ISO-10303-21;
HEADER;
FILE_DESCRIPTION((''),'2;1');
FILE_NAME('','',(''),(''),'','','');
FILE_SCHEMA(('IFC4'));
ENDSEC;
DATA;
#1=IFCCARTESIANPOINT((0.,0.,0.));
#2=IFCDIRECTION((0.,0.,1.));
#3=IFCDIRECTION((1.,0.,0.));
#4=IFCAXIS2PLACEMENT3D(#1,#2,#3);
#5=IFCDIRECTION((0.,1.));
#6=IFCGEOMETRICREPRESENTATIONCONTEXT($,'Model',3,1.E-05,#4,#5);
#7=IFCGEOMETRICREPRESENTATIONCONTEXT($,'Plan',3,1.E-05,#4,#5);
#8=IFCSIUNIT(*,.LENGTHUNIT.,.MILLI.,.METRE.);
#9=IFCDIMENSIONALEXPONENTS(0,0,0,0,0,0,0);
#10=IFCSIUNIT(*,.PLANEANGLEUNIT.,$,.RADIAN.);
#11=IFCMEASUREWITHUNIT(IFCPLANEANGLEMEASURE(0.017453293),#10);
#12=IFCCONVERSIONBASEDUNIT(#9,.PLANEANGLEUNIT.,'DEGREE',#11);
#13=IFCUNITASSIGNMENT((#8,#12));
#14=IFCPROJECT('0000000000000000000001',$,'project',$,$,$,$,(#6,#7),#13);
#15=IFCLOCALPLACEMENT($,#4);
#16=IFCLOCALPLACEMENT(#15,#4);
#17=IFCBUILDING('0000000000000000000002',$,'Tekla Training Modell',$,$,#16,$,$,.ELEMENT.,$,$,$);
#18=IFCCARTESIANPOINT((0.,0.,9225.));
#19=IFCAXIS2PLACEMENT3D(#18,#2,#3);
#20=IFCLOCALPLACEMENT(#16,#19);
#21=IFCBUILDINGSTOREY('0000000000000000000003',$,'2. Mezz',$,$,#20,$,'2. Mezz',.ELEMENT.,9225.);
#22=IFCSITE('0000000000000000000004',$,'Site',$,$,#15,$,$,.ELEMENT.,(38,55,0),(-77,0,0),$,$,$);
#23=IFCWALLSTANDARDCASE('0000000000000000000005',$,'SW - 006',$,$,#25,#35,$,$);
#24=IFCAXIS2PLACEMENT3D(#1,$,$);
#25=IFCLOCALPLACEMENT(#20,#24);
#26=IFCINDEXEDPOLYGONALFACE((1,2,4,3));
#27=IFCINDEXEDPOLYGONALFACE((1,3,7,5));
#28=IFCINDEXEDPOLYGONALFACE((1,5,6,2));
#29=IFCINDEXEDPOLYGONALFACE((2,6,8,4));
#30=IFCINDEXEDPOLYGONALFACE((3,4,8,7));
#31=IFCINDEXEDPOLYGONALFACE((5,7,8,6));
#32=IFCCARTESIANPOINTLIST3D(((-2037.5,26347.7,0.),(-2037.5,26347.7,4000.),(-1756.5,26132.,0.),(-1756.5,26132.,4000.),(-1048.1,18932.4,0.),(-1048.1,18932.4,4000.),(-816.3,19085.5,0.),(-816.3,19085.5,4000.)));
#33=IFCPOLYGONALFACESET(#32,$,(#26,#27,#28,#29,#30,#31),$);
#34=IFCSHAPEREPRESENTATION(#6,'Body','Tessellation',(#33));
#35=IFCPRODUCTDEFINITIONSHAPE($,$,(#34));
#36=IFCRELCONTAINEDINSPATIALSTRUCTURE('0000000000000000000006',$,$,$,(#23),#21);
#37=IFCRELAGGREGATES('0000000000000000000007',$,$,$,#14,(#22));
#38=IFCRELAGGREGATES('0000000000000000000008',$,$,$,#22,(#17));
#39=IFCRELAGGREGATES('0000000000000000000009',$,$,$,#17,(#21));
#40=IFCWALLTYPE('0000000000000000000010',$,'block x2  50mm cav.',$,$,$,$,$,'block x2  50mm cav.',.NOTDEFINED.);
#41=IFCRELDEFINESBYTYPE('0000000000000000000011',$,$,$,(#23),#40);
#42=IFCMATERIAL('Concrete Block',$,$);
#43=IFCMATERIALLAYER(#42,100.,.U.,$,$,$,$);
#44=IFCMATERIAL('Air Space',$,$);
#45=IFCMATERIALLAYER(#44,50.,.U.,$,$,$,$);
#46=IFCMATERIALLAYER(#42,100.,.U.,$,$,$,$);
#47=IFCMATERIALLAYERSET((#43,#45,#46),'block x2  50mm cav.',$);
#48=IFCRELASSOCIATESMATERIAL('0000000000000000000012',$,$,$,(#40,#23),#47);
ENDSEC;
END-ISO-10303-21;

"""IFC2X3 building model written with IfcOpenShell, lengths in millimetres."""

from ifc_helpers import new_model, entity, si_unit, converted_unit, direction, frame, origin_with_axes, place, context, project, spatial, polyline, outline, extrude, material, layer, layer_set, layer_usage, type_object, element, save


model = new_model("IFC2X3")

# Units and contexts
model_context = context("Model", 3, precision=1e-05, world=origin_with_axes(), true_north=direction((0.0, 1.0)))
plan_context = context("Plan", 3, precision=1e-05, world=origin_with_axes(), true_north=direction((0.0, 1.0)))
ifc_project = project(units=[si_unit("LENGTHUNIT", "METRE", prefix="MILLI"), converted_unit("PLANEANGLEUNIT", "DEGREE", entity("IfcPlaneAngleMeasure", 0.017453293), si_unit("PLANEANGLEUNIT", "RADIAN"), dimensions=[0, 0, 0, 0, 0, 0, 0])], contexts=[model_context, plan_context])

# Site, building, storey
site_placement = place(None, origin_with_axes())
site = spatial("IfcSite", under=ifc_project, at=site_placement, Name="Site", CompositionType="ELEMENT", RefLatitude=(38, 55, 0), RefLongitude=(-77, 0, 0))
building_placement = place(site_placement, origin_with_axes())
building = spatial("IfcBuilding", under=site, at=building_placement, Name="Tekla Training Modell", CompositionType="ELEMENT")
storey_placement = place(building_placement, frame((0.0, 0.0, 9225.0), z_axis=(0.0, 0.0, 1.0), x_axis=(1.0, 0.0, 0.0)))
storey = spatial("IfcBuildingStorey", under=building, at=storey_placement, Name="2. Mezz", LongName="2. Mezz", CompositionType="ELEMENT", Elevation=9225.0)

# Wall
ifc_material_1 = material(Name="Concrete Block")
ifc_layer_1 = layer(ifc_material_1, 100.0, ventilated="UNKNOWN")
ifc_material_2 = material(Name="Air Space")
ifc_layer_2 = layer(ifc_material_2, 50.0, ventilated="UNKNOWN")
ifc_layer_3 = layer(ifc_material_1, 100.0, ventilated="UNKNOWN")
ifc_layer_set_1 = layer_set([ifc_layer_1, ifc_layer_2, ifc_layer_3], Name="block x2  50mm cav.")
wall_type = type_object("IfcWallType", Name="block x2  50mm cav.", ElementType="block x2  50mm cav.", PredefinedType="NOTDEFINED", material=ifc_layer_set_1)
ifc_layer_usage_1 = layer_usage(ifc_layer_set_1, "AXIS2", "NEGATIVE", 0.0)
wall_1_placement = place(storey_placement, frame((-1756.5, 26132.0, 0.0), z_axis=(0.0, 0.0, 1.0), x_axis=(0.132257, -0.991215, 0.0)))
element("IfcWallStandardCase", 1, at=wall_1_placement, inside=storey, type_object=wall_type, material=ifc_layer_usage_1, Name="SW - 006", context=model_context, shape_type="SweptSolid", body=[
    extrude(outline(polyline([(-251.0, -250.0), (7230.0, -250.0), (7109.0, 0.0), (0.0, 0.0), (-251.0, -250.0)])), origin_with_axes(), (0.0, 0.0, 1.0), 4000.0),
])

save(model, "model.ifc")
